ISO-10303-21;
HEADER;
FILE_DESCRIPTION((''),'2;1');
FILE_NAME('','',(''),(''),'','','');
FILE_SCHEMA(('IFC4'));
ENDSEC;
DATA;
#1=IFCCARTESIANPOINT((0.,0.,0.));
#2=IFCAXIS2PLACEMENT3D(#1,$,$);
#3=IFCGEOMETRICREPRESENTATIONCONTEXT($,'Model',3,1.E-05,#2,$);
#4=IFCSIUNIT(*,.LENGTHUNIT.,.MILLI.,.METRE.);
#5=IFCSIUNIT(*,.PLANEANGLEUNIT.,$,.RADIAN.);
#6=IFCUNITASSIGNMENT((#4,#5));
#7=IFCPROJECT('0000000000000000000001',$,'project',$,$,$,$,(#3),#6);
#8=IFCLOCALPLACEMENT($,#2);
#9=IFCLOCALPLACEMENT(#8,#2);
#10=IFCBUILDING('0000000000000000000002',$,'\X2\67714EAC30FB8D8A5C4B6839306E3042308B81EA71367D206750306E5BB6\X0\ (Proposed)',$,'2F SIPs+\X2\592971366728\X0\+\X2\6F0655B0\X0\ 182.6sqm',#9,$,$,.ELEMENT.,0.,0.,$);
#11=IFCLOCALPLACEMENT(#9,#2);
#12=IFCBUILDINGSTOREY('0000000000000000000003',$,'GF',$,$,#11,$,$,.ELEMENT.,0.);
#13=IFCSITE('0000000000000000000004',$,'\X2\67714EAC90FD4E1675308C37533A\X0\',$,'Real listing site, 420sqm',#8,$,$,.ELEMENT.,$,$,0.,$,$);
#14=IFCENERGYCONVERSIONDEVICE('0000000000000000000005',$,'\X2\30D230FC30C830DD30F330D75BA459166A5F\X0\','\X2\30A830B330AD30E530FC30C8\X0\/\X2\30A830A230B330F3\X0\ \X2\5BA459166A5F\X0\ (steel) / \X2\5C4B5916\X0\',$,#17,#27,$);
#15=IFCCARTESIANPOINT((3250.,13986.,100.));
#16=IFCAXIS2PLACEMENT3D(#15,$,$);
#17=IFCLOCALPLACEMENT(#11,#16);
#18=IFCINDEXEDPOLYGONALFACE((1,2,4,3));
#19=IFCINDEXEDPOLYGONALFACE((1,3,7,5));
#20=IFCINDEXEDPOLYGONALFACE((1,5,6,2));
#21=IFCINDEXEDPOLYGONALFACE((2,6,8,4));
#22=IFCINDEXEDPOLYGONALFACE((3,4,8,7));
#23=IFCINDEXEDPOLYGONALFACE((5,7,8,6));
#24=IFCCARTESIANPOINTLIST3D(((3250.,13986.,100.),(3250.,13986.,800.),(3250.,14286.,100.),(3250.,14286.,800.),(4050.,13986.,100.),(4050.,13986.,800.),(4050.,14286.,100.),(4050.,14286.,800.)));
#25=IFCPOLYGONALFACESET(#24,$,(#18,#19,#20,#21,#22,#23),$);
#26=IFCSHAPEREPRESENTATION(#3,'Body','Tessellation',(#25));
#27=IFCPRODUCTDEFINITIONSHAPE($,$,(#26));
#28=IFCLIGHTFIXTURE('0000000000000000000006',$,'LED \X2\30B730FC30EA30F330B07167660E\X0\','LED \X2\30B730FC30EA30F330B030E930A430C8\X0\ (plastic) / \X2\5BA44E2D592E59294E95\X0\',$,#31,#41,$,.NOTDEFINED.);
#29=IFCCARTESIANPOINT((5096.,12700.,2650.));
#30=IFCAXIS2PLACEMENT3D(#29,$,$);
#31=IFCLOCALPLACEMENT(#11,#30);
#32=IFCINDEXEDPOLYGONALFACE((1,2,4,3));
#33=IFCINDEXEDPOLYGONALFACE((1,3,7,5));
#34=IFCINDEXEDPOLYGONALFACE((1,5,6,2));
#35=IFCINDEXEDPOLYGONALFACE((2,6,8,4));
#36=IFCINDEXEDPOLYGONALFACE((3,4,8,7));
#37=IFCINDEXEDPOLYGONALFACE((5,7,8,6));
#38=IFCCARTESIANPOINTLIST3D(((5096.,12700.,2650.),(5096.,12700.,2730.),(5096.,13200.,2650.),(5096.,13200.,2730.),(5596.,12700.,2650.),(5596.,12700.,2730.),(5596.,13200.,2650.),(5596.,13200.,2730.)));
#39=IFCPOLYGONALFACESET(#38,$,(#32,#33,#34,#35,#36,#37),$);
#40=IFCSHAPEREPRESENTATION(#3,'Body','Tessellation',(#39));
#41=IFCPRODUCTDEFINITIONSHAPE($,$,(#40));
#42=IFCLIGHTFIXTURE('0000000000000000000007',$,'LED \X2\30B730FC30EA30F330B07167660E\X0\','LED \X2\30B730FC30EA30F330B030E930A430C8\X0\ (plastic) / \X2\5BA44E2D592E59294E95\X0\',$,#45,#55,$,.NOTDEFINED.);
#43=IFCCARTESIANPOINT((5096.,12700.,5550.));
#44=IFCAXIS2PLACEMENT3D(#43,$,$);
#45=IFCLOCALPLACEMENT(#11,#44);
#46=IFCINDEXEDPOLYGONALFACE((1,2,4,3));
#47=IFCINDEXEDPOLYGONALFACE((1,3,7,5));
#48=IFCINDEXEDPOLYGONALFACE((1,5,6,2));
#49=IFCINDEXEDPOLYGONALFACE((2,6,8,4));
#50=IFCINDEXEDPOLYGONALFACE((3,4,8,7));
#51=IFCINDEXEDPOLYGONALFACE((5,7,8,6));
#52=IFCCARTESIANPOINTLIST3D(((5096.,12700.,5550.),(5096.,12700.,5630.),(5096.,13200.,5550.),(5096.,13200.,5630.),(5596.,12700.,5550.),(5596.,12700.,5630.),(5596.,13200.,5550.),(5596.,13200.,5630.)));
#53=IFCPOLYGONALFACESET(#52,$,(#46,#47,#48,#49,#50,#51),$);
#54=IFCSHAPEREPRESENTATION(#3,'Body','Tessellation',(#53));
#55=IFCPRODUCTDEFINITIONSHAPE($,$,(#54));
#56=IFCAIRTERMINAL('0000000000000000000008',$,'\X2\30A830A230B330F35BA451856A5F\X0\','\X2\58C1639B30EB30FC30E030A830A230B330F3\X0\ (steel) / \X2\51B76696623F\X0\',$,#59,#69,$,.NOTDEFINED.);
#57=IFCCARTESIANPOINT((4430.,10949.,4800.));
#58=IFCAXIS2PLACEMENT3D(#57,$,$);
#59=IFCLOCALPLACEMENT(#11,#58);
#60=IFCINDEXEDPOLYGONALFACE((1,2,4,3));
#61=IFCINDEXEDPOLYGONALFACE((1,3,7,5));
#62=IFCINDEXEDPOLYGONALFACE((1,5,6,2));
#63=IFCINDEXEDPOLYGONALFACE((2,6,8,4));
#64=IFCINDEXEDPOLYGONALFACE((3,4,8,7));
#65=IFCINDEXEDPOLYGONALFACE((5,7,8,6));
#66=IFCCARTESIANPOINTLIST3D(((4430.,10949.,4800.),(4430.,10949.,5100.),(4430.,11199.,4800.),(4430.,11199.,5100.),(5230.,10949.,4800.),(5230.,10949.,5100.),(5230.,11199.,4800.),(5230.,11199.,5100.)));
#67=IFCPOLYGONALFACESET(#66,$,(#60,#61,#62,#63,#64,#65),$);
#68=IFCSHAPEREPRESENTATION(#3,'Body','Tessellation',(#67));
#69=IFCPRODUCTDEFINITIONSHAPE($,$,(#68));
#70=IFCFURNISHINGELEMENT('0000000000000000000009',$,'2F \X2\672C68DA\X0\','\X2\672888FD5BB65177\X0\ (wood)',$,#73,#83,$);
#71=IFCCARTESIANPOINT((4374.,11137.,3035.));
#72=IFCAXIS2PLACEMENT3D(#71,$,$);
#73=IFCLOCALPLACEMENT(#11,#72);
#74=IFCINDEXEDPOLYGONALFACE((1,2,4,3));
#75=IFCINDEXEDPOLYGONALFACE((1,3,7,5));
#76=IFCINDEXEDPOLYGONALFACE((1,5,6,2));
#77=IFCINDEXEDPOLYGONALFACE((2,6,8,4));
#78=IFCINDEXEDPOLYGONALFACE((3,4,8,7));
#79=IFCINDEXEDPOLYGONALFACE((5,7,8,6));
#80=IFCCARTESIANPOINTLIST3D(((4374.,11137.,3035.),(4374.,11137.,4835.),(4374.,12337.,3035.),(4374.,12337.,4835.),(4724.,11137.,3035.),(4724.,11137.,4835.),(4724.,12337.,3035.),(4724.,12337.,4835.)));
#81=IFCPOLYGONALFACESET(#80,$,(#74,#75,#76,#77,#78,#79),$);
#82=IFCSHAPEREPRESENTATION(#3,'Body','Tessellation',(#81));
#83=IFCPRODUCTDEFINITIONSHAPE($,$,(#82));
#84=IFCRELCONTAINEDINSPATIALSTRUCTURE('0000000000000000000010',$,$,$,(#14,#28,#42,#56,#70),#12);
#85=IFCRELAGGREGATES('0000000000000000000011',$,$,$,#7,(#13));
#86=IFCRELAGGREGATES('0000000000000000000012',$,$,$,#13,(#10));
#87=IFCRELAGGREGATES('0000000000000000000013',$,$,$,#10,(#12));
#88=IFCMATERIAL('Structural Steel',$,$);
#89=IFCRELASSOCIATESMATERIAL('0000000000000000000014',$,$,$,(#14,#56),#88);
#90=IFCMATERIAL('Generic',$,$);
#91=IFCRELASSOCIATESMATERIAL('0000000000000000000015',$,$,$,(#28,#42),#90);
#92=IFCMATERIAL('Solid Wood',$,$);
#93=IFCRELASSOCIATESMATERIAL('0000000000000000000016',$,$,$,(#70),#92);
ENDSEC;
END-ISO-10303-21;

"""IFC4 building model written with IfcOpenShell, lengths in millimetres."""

from ifc_helpers import new_model, si_unit, frame, frame_2d, origin, place, context, project, spatial, rectangle, extrude, material, element, save


model = new_model("IFC4")

# Units and contexts
model_context = context("Model", 3, precision=1e-05, world=origin())
ifc_project = project(units=[si_unit("LENGTHUNIT", "METRE", prefix="MILLI"), si_unit("PLANEANGLEUNIT", "RADIAN")], contexts=[model_context])

# Site, building, storey
site_placement = place(None, origin())
site = spatial("IfcSite", under=ifc_project, at=site_placement, Name="東京都世田谷区", ObjectType="Real listing site, 420sqm", CompositionType="ELEMENT", RefElevation=0.0)
building_placement = place(site_placement, origin())
building = spatial("IfcBuilding", under=site, at=building_placement, Name="東京・越屋根のある自然素材の家 (Proposed)", ObjectType="2F SIPs+天然木+漆喰 182.6sqm", CompositionType="ELEMENT", ElevationOfRefHeight=0.0, ElevationOfTerrain=0.0)
storey_placement = place(building_placement, origin())
storey = spatial("IfcBuildingStorey", under=building, at=storey_placement, Name="GF", CompositionType="ELEMENT", Elevation=0.0)

# Shared definitions
ifc_material_1 = material(Name="Solid Wood")

# Shared definitions
ifc_material_2 = material(Name="Structural Steel")

# Shared definitions
ifc_material_3 = material(Name="Generic")

# Energy conversion device
energy_conversion_device_placement = place(storey_placement, frame((3250.0, 13986.0, 100.0)))
element("IfcEnergyConversionDevice", 1, at=energy_conversion_device_placement, inside=storey, material=ifc_material_2, Name="ヒートポンプ室外機", Description="エコキュート/エアコン 室外機 (steel) / 屋外", context=model_context, shape_type="SweptSolid", body=[
    extrude(rectangle(XDim=800.0, YDim=300.0, at=frame_2d((400.0, 150.0))), frame((3250.0, 13986.0, 100.0)), (0.0, 0.0, 1.0), 700.0),
])

# Light fixtures
light_fixture_1_placement = place(storey_placement, frame((5096.0, 12700.0, 2650.0)))
element("IfcLightFixture", 2, at=light_fixture_1_placement, inside=storey, material=ifc_material_3, Name="LED シーリング照明", Description="LED シーリングライト (plastic) / 室中央天井", PredefinedType="NOTDEFINED", context=model_context, shape_type="SweptSolid", body=[
    extrude(rectangle(XDim=500.0, YDim=500.0, at=frame_2d((250.0, 250.0))), frame((5096.0, 12700.0, 2650.0)), (0.0, 0.0, 1.0), 80.0),
])
light_fixture_2_placement = place(storey_placement, frame((5096.0, 12700.0, 5550.0)))
element("IfcLightFixture", 3, at=light_fixture_2_placement, inside=storey, material=ifc_material_3, Name="LED シーリング照明", Description="LED シーリングライト (plastic) / 室中央天井", PredefinedType="NOTDEFINED", context=model_context, shape_type="SweptSolid", body=[
    extrude(rectangle(XDim=500.0, YDim=500.0, at=frame_2d((250.0, 250.0))), frame((5096.0, 12700.0, 5550.0)), (0.0, 0.0, 1.0), 80.0),
])

# Air terminal
air_terminal_placement = place(storey_placement, frame((4430.0, 10949.0, 4800.0)))
element("IfcAirTerminal", 4, at=air_terminal_placement, inside=storey, material=ifc_material_2, Name="エアコン室内機", Description="壁掛ルームエアコン (steel) / 冷暖房", PredefinedType="NOTDEFINED", context=model_context, shape_type="SweptSolid", body=[
    extrude(rectangle(XDim=800.0, YDim=250.0, at=frame_2d((400.0, 125.0))), frame((4430.0, 10949.0, 4800.0)), (0.0, 0.0, 1.0), 300.0),
])

# Furnishing element
furnishing_placement = place(storey_placement, frame((4374.0, 11137.0, 3035.0)))
element("IfcFurnishingElement", 5, at=furnishing_placement, inside=storey, material=ifc_material_1, Name="2F 本棚", Description="木製家具 (wood)", context=model_context, shape_type="SweptSolid", body=[
    extrude(rectangle(XDim=350.0, YDim=1200.0, at=frame_2d((175.0, 600.0))), frame((4374.0, 11137.0, 3035.0)), (0.0, 0.0, 1.0), 1800.0),
])

save(model, "model.ifc")
